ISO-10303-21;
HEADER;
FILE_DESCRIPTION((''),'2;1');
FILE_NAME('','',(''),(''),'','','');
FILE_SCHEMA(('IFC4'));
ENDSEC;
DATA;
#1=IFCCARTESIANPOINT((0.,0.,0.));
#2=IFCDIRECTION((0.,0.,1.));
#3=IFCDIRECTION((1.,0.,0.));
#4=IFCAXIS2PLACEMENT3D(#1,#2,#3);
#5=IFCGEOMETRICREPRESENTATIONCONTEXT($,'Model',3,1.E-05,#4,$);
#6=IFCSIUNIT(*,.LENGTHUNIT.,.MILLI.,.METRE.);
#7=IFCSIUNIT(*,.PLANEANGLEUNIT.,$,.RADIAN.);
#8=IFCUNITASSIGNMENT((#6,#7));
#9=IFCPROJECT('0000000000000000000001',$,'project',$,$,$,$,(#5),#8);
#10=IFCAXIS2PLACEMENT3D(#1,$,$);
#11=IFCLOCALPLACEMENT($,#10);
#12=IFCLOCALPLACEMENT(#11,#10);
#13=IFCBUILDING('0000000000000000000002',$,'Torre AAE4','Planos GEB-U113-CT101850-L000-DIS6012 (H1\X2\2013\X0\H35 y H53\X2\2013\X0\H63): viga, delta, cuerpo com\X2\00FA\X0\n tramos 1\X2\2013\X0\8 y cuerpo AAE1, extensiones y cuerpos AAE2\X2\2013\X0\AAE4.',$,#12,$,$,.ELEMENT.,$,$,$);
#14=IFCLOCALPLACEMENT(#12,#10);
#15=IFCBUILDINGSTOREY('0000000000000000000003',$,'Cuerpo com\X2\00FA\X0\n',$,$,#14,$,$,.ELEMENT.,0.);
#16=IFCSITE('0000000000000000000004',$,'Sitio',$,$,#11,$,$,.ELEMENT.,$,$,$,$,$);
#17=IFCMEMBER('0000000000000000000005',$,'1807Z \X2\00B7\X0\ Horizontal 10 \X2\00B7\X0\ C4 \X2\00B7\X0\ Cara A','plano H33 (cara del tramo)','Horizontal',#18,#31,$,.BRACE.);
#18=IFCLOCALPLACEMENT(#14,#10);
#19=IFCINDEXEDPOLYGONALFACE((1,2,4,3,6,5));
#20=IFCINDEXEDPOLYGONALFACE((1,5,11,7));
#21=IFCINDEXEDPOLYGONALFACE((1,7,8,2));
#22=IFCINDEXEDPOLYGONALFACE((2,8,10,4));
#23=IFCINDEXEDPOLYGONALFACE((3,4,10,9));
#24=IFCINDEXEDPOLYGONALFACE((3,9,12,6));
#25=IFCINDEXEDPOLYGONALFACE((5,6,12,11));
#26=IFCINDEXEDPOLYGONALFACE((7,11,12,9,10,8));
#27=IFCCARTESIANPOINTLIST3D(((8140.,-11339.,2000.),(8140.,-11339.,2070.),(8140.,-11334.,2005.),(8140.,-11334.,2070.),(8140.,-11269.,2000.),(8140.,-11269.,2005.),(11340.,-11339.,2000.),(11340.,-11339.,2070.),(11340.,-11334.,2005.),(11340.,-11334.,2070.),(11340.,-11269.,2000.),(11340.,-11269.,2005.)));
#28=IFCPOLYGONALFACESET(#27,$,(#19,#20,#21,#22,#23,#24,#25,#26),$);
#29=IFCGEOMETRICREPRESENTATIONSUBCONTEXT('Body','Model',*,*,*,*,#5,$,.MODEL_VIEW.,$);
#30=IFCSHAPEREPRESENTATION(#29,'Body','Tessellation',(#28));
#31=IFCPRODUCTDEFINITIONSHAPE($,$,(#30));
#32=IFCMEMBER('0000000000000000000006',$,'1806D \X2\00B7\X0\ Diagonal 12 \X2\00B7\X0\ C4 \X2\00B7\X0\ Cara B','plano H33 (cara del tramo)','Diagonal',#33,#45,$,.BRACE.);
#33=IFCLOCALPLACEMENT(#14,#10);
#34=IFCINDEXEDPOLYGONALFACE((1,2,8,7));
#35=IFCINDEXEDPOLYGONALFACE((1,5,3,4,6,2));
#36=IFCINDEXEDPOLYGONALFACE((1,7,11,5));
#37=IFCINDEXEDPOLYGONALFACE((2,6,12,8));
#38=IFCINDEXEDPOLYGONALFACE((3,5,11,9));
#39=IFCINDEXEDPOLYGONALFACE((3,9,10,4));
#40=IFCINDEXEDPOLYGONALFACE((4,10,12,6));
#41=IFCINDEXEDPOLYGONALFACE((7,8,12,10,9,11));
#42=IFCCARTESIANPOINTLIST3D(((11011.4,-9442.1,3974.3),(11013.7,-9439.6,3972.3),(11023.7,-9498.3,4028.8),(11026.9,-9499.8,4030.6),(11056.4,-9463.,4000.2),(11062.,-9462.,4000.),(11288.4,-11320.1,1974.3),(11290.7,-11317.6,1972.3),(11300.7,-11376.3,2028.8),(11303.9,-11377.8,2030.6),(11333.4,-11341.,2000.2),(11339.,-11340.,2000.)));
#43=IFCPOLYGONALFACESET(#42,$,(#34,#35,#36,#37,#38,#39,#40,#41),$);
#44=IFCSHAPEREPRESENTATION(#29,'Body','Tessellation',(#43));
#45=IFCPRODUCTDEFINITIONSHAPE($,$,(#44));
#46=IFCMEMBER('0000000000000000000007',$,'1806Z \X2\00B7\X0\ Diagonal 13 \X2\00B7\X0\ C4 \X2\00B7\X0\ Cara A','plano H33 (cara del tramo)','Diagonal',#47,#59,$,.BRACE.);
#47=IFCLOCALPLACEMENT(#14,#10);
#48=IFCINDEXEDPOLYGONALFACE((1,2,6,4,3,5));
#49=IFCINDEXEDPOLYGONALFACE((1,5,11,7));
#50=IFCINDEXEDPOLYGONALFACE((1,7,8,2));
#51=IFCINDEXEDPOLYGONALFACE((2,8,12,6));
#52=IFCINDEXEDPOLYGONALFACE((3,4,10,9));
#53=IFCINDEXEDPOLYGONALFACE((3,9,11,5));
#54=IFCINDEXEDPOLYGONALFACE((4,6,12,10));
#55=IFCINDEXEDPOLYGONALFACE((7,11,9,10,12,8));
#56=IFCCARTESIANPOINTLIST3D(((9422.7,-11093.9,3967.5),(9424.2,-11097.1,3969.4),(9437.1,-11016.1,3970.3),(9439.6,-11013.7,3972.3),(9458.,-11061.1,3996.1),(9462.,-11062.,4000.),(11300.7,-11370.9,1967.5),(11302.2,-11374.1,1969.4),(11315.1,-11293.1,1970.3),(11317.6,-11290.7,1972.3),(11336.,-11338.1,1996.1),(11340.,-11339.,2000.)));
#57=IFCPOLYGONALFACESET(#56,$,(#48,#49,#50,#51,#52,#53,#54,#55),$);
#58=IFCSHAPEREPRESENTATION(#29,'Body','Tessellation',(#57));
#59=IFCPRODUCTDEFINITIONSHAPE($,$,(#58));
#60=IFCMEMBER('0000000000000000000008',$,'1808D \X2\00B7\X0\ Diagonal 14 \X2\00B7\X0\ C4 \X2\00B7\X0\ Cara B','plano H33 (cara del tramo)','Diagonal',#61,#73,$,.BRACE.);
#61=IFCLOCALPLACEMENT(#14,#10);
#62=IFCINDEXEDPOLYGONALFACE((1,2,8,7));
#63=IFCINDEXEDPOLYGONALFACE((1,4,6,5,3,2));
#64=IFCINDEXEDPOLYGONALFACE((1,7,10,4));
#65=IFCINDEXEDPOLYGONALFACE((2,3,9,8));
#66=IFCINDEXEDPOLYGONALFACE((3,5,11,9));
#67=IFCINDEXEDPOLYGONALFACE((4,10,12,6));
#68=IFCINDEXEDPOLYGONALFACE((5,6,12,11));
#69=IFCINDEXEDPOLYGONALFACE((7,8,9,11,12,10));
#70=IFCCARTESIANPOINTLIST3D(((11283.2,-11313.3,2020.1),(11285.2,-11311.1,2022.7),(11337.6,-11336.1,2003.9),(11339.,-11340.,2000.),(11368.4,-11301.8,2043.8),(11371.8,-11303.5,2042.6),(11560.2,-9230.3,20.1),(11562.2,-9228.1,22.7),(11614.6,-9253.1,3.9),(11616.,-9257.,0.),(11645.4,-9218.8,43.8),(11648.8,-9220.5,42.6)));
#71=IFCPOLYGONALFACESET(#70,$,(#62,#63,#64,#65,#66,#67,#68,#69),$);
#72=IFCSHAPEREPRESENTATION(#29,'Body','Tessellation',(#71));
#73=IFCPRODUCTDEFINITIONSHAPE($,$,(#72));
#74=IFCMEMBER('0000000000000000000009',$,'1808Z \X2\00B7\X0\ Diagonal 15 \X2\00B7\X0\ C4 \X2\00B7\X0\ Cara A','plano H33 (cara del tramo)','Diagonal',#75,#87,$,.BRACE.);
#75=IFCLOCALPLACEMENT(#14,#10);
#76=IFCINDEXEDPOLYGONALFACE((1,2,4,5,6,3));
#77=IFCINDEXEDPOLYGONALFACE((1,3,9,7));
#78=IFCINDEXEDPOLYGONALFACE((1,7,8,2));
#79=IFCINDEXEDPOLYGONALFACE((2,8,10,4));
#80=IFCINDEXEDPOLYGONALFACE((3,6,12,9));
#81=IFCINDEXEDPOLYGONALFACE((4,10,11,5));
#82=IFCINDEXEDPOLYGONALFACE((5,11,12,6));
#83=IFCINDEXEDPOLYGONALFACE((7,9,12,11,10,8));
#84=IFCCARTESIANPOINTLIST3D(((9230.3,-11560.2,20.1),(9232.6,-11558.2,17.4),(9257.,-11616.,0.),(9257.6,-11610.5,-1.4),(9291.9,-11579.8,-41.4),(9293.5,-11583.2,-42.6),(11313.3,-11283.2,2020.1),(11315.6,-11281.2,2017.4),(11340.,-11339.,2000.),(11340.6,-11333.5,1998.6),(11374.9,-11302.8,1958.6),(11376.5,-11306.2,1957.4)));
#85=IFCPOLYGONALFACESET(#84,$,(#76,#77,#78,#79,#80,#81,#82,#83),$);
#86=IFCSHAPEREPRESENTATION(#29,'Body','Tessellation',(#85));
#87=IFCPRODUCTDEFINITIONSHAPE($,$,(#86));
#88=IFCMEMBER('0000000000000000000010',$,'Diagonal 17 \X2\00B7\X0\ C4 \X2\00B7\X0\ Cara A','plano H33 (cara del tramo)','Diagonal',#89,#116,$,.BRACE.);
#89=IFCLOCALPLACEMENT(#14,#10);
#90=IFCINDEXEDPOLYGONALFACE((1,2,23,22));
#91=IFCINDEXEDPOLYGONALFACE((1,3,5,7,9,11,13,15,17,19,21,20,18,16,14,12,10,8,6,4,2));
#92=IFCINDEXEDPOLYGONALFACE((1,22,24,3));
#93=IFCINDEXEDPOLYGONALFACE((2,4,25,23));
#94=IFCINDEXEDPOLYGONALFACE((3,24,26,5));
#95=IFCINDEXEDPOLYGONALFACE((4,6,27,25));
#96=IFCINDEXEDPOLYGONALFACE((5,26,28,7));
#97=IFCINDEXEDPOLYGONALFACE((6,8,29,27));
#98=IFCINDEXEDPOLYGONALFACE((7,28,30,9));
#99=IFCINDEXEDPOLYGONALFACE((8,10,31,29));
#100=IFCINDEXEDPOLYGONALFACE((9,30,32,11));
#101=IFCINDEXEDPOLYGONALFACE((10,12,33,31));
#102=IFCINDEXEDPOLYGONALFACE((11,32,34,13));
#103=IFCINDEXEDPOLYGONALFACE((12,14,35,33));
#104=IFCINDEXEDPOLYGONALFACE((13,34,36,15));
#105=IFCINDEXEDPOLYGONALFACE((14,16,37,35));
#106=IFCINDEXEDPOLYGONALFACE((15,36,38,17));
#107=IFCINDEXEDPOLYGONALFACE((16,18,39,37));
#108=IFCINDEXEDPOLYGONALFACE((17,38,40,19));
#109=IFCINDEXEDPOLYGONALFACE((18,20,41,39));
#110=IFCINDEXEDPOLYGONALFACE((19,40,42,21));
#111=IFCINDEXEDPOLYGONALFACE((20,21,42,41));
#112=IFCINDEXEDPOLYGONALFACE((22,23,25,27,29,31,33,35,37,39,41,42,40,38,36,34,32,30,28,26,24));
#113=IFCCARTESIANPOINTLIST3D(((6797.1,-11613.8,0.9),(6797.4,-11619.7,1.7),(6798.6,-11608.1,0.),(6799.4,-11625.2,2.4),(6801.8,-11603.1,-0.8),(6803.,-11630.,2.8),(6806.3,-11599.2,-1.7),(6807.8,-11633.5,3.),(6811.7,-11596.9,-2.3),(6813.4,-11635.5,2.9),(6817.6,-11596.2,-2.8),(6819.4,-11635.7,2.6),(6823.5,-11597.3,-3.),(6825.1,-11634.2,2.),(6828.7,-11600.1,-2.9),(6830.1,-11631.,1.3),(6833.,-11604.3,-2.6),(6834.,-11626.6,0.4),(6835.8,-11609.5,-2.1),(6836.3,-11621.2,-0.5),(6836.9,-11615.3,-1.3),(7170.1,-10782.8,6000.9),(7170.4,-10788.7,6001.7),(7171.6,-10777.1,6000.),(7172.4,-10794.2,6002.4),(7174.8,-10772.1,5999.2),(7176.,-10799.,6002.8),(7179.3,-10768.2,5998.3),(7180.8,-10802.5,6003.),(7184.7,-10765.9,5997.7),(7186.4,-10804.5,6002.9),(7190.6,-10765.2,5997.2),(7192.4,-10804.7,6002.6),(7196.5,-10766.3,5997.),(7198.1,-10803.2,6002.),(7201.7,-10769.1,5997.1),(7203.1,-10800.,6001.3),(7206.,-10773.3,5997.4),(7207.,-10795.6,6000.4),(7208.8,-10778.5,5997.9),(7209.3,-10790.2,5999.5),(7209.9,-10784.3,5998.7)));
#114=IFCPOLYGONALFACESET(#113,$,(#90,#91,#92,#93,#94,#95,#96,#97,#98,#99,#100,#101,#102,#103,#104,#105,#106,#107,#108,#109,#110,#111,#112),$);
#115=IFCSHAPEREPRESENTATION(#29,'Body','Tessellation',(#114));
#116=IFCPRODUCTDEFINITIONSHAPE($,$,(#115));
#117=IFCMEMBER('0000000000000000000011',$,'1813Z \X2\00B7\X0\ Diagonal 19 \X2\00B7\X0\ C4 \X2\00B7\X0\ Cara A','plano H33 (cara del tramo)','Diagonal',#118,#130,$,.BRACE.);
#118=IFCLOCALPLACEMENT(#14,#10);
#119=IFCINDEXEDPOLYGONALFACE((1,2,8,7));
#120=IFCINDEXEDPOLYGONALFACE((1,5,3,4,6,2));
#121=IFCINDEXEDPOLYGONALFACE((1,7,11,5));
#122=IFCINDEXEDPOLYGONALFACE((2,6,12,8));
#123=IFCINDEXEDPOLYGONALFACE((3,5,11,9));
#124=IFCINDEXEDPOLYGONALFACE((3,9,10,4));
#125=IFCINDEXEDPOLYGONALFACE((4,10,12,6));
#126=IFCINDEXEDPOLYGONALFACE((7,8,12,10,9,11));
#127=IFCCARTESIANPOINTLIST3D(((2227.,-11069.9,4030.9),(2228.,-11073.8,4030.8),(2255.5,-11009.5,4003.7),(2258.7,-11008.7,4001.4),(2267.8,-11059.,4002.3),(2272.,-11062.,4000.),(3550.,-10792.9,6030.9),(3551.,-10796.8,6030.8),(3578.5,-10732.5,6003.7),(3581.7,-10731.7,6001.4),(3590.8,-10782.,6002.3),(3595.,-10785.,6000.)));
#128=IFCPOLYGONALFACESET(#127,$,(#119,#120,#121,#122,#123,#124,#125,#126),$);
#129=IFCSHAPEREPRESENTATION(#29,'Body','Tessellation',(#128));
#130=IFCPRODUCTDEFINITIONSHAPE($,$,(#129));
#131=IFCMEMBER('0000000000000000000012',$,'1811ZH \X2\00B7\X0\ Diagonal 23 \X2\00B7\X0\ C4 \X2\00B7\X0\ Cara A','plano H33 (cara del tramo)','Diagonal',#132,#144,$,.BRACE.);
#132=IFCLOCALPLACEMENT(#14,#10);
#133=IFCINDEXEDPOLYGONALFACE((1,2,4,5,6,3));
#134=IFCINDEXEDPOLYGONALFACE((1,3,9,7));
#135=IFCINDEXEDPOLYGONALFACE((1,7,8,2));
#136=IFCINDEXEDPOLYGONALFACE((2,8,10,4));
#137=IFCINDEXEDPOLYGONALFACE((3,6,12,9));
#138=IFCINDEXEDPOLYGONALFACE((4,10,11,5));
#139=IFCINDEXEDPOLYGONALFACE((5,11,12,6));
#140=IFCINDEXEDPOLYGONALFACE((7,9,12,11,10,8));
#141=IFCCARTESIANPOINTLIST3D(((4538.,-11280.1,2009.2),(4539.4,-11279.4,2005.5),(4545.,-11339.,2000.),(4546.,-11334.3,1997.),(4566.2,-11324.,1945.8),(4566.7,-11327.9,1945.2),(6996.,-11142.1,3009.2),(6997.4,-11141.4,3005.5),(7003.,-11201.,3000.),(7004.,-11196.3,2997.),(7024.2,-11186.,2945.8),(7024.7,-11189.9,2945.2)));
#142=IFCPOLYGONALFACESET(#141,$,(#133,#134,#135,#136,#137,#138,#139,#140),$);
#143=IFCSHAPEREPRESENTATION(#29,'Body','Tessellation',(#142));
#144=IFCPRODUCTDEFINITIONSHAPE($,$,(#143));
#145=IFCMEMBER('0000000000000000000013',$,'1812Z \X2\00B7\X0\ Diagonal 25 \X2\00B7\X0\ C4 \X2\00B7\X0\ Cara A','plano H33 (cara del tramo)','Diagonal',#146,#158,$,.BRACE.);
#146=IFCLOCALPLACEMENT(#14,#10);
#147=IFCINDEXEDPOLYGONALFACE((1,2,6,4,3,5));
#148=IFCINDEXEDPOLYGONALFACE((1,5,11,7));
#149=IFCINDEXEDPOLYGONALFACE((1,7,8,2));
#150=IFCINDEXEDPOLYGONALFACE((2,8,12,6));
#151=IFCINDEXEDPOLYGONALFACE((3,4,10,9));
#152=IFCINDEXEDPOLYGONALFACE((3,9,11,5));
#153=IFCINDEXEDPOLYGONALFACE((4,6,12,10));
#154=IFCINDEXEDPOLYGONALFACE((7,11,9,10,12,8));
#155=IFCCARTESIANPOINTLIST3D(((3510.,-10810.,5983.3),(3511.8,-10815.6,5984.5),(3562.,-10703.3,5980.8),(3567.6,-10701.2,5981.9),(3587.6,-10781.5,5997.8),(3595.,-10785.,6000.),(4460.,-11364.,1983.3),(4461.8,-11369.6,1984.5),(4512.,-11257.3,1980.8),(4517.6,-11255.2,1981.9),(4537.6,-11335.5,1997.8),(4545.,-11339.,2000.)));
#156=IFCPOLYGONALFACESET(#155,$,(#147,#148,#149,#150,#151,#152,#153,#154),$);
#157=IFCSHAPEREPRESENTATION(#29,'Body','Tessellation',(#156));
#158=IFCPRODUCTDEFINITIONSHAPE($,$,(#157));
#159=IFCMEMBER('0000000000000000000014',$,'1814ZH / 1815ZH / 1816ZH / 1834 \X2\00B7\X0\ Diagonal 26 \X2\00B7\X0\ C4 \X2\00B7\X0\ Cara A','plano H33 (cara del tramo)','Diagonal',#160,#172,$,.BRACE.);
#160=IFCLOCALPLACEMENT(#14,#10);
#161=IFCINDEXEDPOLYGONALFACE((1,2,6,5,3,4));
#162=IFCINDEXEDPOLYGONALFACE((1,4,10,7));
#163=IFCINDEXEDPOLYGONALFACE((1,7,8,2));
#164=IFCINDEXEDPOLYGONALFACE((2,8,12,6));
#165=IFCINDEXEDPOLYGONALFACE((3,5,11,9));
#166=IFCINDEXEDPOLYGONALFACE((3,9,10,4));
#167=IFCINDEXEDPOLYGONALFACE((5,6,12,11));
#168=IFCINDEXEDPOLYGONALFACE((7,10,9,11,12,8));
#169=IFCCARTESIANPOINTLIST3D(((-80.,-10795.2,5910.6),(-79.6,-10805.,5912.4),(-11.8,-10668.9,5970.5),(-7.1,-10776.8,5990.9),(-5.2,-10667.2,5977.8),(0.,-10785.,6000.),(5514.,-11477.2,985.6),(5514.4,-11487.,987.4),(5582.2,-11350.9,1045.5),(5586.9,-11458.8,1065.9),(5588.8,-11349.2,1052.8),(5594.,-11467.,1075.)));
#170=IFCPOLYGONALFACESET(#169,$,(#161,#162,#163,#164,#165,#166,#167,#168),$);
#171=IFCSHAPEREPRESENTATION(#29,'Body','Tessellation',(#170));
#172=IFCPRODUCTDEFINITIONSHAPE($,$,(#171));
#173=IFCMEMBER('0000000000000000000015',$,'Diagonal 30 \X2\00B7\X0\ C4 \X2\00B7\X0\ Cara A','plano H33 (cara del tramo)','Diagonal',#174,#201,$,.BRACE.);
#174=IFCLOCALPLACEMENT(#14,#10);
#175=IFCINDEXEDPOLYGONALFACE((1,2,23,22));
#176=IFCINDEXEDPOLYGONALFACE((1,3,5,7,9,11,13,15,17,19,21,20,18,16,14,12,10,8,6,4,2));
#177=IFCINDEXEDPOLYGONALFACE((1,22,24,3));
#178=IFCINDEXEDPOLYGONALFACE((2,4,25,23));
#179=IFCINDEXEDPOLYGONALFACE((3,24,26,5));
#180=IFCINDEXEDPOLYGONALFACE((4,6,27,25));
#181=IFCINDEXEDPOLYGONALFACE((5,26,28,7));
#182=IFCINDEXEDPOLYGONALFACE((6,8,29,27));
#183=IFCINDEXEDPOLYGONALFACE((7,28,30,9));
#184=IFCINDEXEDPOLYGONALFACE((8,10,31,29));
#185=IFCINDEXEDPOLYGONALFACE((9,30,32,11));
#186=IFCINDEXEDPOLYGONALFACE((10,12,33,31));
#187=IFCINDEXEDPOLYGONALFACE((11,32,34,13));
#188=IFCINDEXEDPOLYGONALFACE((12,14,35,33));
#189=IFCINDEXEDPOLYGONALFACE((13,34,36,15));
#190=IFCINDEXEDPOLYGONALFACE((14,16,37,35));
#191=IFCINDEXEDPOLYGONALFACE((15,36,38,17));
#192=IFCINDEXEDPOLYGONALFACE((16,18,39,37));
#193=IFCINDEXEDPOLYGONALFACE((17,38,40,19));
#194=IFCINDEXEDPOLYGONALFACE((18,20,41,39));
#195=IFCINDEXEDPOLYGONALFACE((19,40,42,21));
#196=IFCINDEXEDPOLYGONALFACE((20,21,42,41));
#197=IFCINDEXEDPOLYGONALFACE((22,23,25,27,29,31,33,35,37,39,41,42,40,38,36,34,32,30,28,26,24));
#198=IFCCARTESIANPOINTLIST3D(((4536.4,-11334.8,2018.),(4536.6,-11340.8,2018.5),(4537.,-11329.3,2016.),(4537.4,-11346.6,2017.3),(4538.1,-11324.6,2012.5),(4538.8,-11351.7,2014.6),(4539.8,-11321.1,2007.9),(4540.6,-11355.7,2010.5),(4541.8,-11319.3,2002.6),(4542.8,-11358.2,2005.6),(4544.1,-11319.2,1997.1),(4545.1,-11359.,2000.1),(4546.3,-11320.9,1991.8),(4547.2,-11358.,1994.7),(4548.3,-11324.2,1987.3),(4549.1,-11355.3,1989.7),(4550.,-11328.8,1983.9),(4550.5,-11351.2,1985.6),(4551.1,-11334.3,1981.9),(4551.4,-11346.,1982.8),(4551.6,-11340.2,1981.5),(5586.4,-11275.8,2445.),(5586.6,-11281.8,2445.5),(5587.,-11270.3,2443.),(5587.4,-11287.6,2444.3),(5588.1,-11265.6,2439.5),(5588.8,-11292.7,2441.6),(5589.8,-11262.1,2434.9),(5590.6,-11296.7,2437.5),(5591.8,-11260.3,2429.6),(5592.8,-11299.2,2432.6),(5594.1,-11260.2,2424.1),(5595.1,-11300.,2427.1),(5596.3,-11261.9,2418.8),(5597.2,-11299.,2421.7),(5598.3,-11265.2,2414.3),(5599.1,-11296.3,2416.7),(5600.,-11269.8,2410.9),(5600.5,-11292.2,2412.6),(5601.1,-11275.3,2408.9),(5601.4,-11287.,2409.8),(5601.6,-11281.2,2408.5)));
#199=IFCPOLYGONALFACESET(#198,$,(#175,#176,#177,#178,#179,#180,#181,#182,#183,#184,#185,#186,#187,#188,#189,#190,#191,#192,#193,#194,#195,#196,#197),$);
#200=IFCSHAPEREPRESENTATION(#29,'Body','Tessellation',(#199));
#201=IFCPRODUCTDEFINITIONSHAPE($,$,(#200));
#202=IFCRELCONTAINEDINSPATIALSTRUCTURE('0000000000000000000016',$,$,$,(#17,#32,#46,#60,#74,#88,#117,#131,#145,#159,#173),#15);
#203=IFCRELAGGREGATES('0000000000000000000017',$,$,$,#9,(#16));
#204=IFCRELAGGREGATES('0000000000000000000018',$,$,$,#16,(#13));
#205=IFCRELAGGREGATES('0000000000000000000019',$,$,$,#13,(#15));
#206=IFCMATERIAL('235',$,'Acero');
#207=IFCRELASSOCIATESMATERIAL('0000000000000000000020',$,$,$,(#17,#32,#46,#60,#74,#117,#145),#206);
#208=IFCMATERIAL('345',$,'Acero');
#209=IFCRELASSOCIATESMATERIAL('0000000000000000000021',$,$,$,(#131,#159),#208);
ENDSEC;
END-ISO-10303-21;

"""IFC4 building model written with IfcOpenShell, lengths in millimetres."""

from ifc_helpers import new_model, si_unit, frame, frame_2d, origin, origin_with_axes, place, context, subcontext, project, spatial, circle, l_section, extrude, material, element, save


model = new_model("IFC4")

# Units and contexts
model_context = context("Model", 3, precision=1e-05, world=origin_with_axes())
body_context = subcontext(model_context, "Body", "Model", "MODEL_VIEW")
ifc_project = project(units=[si_unit("LENGTHUNIT", "METRE", prefix="MILLI"), si_unit("PLANEANGLEUNIT", "RADIAN")], contexts=[model_context])

# Site, building, storey
site_placement = place(None, origin())
site = spatial("IfcSite", under=ifc_project, at=site_placement, Name="Sitio", CompositionType="ELEMENT")
building_placement = place(site_placement, origin())
building = spatial("IfcBuilding", under=site, at=building_placement, Name="Torre AAE4", Description="Planos GEB-U113-CT101850-L000-DIS6012 (H1–H35 y H53–H63): viga, delta, cuerpo común tramos 1–8 y cuerpo AAE1, extensiones y cuerpos AAE2–AAE4.", CompositionType="ELEMENT")
storey_placement = place(building_placement, origin())
storey = spatial("IfcBuildingStorey", under=building, at=storey_placement, Name="Cuerpo común", CompositionType="ELEMENT", Elevation=0.0)

# Members
ifc_material_1 = material(Name="345", Category="Acero")
ifc_material_2 = material(Name="235", Category="Acero")
member_1_placement = place(storey_placement, frame((8140.0, -11339.0, 2000.0), z_axis=(1.0, 0.0, 0.0), x_axis=(0.0, 1.0, 0.0)))
element("IfcMember", 1, at=member_1_placement, inside=storey, material=ifc_material_2, Name="1807Z · Horizontal 10 · C4 · Cara A", Description="plano H33 (cara del tramo)", ObjectType="Horizontal", PredefinedType="BRACE", context=body_context, shape_type="SweptSolid", body=[
    extrude(l_section(Depth=70.0, Width=70.0, Thickness=5.0, at=frame_2d((35.0, 35.0))), None, (0.0, 0.0, 1.0), 3200.0),
])
for number, where, z_axis, x_axis, name in (
    (2, (11339.0, -11340.0, 2000.0), (-0.100455, 0.68106, 0.725304), (-0.804727, 0.373073, -0.46177), "1806D · Diagonal 12 · C4 · Cara B"),
    (3, (11340.0, -11339.0, 2000.0), (-0.68106, 0.100455, 0.725304), (-0.373073, 0.804727, -0.46177), "1806Z · Diagonal 13 · C4 · Cara A"),
):
    element("IfcMember", number, at=place(storey_placement, frame(where, z_axis=z_axis, x_axis=x_axis)), inside=storey, material=ifc_material_2, Name=name, Description="plano H33 (cara del tramo)", ObjectType="Diagonal", PredefinedType="BRACE", context=body_context, shape_type="SweptSolid", body=[
        extrude(l_section(Depth=60.0, Width=60.0, Thickness=4.0, at=frame_2d((30.0, 30.0))), None, (0.0, 0.0, 1.0), 2757.5),
    ])
for number, where, z_axis, x_axis, name in (
    (4, (11339.0, -11340.0, 2000.0), (0.095485, 0.718036, -0.689425), (-0.858158, 0.410344, 0.308518), "1808D · Diagonal 14 · C4 · Cara B"),
    (5, (11340.0, -11339.0, 2000.0), (-0.718036, -0.095485, -0.689425), (-0.410344, 0.858158, 0.308518), "1808Z · Diagonal 15 · C4 · Cara A"),
):
    element("IfcMember", number, at=place(storey_placement, frame(where, z_axis=z_axis, x_axis=x_axis)), inside=storey, material=ifc_material_2, Name=name, Description="plano H33 (cara del tramo)", ObjectType="Diagonal", PredefinedType="BRACE", context=body_context, shape_type="SweptSolid", body=[
        extrude(l_section(Depth=65.0, Width=65.0, Thickness=4.0, at=frame_2d((32.5, 32.5))), None, (0.0, 0.0, 1.0), 2901.0),
    ])
member_2_placement = place(storey_placement, frame((6817.0, -11616.0, 0.0), z_axis=(0.061462, 0.136931, 0.988672), x_axis=(-0.537182, 0.839386, -0.08286)))
element("IfcMember", 6, at=member_2_placement, inside=storey, Name="Diagonal 17 · C4 · Cara A", Description="plano H33 (cara del tramo)", ObjectType="Diagonal", PredefinedType="BRACE", context=body_context, shape_type="SweptSolid", body=[
    extrude(circle(Radius=20.0), None, (0.0, 0.0, 1.0), 6068.7),
])
member_3_placement = place(storey_placement, frame((2272.0, -11062.0, 4000.0), z_axis=(0.548069, 0.114751, 0.828524), x_axis=(-0.242312, 0.969851, 0.025965)))
element("IfcMember", 7, at=member_3_placement, inside=storey, material=ifc_material_2, Name="1813Z · Diagonal 19 · C4 · Cara A", Description="plano H33 (cara del tramo)", ObjectType="Diagonal", PredefinedType="BRACE", context=body_context, shape_type="SweptSolid", body=[
    extrude(l_section(Depth=55.0, Width=55.0, Thickness=4.0, at=frame_2d((27.5, 27.5))), None, (0.0, 0.0, 1.0), 2413.9),
])
member_4_placement = place(storey_placement, frame((7003.0, -11201.0, 3000.0), z_axis=(-0.925028, -0.051934, -0.376333), x_axis=(-0.117139, 0.981337, 0.152502)))
element("IfcMember", 8, at=member_4_placement, inside=storey, material=ifc_material_1, Name="1811ZH · Diagonal 23 · C4 · Cara A", Description="plano H33 (cara del tramo)", ObjectType="Diagonal", PredefinedType="BRACE", context=body_context, shape_type="SweptSolid", body=[
    extrude(l_section(Depth=60.0, Width=60.0, Thickness=4.0, at=frame_2d((30.0, 30.0))), None, (0.0, 0.0, 1.0), 2657.2),
])
member_5_placement = place(storey_placement, frame((4545.0, -11339.0, 2000.0), z_axis=(-0.229003, 0.133545, 0.964222), x_axis=(-0.304925, 0.93085, -0.201342)))
element("IfcMember", 9, at=member_5_placement, inside=storey, material=ifc_material_2, Name="1812Z · Diagonal 25 · C4 · Cara A", Description="plano H33 (cara del tramo)", ObjectType="Diagonal", PredefinedType="BRACE", context=body_context, shape_type="SweptSolid", body=[
    extrude(l_section(Depth=90.0, Width=90.0, Thickness=6.0, at=frame_2d((45.0, 45.0))), None, (0.0, 0.0, 1.0), 4148.4),
])
member_6_placement = place(storey_placement, frame((5594.0, -11467.0, 1075.0), z_axis=(-0.747439, 0.091125, 0.658051), x_axis=(-0.043156, 0.981795, -0.184974)))
element("IfcMember", 10, at=member_6_placement, inside=storey, material=ifc_material_1, Name="1814ZH / 1815ZH / 1816ZH / 1834 · Diagonal 26 · C4 · Cara A", Description="plano H33 (cara del tramo)", ObjectType="Diagonal", PredefinedType="BRACE", context=body_context, shape_type="SweptSolid", body=[
    extrude(l_section(Depth=120.0, Width=120.0, Thickness=10.0, at=frame_2d((60.0, 60.0))), None, (0.0, 0.0, 1.0), 7484.2),
])
member_7_placement = place(storey_placement, frame((5594.0, -11280.0, 2427.0), z_axis=(-0.92508, -0.051981, -0.376199), x_axis=(-0.109012, 0.985247, 0.131928)))
element("IfcMember", 11, at=member_7_placement, inside=storey, Name="Diagonal 30 · C4 · Cara A", Description="plano H33 (cara del tramo)", ObjectType="Diagonal", PredefinedType="BRACE", context=body_context, shape_type="SweptSolid", body=[
    extrude(circle(Radius=20.0), None, (0.0, 0.0, 1.0), 1135.0),
])

save(model, "model.ifc")
